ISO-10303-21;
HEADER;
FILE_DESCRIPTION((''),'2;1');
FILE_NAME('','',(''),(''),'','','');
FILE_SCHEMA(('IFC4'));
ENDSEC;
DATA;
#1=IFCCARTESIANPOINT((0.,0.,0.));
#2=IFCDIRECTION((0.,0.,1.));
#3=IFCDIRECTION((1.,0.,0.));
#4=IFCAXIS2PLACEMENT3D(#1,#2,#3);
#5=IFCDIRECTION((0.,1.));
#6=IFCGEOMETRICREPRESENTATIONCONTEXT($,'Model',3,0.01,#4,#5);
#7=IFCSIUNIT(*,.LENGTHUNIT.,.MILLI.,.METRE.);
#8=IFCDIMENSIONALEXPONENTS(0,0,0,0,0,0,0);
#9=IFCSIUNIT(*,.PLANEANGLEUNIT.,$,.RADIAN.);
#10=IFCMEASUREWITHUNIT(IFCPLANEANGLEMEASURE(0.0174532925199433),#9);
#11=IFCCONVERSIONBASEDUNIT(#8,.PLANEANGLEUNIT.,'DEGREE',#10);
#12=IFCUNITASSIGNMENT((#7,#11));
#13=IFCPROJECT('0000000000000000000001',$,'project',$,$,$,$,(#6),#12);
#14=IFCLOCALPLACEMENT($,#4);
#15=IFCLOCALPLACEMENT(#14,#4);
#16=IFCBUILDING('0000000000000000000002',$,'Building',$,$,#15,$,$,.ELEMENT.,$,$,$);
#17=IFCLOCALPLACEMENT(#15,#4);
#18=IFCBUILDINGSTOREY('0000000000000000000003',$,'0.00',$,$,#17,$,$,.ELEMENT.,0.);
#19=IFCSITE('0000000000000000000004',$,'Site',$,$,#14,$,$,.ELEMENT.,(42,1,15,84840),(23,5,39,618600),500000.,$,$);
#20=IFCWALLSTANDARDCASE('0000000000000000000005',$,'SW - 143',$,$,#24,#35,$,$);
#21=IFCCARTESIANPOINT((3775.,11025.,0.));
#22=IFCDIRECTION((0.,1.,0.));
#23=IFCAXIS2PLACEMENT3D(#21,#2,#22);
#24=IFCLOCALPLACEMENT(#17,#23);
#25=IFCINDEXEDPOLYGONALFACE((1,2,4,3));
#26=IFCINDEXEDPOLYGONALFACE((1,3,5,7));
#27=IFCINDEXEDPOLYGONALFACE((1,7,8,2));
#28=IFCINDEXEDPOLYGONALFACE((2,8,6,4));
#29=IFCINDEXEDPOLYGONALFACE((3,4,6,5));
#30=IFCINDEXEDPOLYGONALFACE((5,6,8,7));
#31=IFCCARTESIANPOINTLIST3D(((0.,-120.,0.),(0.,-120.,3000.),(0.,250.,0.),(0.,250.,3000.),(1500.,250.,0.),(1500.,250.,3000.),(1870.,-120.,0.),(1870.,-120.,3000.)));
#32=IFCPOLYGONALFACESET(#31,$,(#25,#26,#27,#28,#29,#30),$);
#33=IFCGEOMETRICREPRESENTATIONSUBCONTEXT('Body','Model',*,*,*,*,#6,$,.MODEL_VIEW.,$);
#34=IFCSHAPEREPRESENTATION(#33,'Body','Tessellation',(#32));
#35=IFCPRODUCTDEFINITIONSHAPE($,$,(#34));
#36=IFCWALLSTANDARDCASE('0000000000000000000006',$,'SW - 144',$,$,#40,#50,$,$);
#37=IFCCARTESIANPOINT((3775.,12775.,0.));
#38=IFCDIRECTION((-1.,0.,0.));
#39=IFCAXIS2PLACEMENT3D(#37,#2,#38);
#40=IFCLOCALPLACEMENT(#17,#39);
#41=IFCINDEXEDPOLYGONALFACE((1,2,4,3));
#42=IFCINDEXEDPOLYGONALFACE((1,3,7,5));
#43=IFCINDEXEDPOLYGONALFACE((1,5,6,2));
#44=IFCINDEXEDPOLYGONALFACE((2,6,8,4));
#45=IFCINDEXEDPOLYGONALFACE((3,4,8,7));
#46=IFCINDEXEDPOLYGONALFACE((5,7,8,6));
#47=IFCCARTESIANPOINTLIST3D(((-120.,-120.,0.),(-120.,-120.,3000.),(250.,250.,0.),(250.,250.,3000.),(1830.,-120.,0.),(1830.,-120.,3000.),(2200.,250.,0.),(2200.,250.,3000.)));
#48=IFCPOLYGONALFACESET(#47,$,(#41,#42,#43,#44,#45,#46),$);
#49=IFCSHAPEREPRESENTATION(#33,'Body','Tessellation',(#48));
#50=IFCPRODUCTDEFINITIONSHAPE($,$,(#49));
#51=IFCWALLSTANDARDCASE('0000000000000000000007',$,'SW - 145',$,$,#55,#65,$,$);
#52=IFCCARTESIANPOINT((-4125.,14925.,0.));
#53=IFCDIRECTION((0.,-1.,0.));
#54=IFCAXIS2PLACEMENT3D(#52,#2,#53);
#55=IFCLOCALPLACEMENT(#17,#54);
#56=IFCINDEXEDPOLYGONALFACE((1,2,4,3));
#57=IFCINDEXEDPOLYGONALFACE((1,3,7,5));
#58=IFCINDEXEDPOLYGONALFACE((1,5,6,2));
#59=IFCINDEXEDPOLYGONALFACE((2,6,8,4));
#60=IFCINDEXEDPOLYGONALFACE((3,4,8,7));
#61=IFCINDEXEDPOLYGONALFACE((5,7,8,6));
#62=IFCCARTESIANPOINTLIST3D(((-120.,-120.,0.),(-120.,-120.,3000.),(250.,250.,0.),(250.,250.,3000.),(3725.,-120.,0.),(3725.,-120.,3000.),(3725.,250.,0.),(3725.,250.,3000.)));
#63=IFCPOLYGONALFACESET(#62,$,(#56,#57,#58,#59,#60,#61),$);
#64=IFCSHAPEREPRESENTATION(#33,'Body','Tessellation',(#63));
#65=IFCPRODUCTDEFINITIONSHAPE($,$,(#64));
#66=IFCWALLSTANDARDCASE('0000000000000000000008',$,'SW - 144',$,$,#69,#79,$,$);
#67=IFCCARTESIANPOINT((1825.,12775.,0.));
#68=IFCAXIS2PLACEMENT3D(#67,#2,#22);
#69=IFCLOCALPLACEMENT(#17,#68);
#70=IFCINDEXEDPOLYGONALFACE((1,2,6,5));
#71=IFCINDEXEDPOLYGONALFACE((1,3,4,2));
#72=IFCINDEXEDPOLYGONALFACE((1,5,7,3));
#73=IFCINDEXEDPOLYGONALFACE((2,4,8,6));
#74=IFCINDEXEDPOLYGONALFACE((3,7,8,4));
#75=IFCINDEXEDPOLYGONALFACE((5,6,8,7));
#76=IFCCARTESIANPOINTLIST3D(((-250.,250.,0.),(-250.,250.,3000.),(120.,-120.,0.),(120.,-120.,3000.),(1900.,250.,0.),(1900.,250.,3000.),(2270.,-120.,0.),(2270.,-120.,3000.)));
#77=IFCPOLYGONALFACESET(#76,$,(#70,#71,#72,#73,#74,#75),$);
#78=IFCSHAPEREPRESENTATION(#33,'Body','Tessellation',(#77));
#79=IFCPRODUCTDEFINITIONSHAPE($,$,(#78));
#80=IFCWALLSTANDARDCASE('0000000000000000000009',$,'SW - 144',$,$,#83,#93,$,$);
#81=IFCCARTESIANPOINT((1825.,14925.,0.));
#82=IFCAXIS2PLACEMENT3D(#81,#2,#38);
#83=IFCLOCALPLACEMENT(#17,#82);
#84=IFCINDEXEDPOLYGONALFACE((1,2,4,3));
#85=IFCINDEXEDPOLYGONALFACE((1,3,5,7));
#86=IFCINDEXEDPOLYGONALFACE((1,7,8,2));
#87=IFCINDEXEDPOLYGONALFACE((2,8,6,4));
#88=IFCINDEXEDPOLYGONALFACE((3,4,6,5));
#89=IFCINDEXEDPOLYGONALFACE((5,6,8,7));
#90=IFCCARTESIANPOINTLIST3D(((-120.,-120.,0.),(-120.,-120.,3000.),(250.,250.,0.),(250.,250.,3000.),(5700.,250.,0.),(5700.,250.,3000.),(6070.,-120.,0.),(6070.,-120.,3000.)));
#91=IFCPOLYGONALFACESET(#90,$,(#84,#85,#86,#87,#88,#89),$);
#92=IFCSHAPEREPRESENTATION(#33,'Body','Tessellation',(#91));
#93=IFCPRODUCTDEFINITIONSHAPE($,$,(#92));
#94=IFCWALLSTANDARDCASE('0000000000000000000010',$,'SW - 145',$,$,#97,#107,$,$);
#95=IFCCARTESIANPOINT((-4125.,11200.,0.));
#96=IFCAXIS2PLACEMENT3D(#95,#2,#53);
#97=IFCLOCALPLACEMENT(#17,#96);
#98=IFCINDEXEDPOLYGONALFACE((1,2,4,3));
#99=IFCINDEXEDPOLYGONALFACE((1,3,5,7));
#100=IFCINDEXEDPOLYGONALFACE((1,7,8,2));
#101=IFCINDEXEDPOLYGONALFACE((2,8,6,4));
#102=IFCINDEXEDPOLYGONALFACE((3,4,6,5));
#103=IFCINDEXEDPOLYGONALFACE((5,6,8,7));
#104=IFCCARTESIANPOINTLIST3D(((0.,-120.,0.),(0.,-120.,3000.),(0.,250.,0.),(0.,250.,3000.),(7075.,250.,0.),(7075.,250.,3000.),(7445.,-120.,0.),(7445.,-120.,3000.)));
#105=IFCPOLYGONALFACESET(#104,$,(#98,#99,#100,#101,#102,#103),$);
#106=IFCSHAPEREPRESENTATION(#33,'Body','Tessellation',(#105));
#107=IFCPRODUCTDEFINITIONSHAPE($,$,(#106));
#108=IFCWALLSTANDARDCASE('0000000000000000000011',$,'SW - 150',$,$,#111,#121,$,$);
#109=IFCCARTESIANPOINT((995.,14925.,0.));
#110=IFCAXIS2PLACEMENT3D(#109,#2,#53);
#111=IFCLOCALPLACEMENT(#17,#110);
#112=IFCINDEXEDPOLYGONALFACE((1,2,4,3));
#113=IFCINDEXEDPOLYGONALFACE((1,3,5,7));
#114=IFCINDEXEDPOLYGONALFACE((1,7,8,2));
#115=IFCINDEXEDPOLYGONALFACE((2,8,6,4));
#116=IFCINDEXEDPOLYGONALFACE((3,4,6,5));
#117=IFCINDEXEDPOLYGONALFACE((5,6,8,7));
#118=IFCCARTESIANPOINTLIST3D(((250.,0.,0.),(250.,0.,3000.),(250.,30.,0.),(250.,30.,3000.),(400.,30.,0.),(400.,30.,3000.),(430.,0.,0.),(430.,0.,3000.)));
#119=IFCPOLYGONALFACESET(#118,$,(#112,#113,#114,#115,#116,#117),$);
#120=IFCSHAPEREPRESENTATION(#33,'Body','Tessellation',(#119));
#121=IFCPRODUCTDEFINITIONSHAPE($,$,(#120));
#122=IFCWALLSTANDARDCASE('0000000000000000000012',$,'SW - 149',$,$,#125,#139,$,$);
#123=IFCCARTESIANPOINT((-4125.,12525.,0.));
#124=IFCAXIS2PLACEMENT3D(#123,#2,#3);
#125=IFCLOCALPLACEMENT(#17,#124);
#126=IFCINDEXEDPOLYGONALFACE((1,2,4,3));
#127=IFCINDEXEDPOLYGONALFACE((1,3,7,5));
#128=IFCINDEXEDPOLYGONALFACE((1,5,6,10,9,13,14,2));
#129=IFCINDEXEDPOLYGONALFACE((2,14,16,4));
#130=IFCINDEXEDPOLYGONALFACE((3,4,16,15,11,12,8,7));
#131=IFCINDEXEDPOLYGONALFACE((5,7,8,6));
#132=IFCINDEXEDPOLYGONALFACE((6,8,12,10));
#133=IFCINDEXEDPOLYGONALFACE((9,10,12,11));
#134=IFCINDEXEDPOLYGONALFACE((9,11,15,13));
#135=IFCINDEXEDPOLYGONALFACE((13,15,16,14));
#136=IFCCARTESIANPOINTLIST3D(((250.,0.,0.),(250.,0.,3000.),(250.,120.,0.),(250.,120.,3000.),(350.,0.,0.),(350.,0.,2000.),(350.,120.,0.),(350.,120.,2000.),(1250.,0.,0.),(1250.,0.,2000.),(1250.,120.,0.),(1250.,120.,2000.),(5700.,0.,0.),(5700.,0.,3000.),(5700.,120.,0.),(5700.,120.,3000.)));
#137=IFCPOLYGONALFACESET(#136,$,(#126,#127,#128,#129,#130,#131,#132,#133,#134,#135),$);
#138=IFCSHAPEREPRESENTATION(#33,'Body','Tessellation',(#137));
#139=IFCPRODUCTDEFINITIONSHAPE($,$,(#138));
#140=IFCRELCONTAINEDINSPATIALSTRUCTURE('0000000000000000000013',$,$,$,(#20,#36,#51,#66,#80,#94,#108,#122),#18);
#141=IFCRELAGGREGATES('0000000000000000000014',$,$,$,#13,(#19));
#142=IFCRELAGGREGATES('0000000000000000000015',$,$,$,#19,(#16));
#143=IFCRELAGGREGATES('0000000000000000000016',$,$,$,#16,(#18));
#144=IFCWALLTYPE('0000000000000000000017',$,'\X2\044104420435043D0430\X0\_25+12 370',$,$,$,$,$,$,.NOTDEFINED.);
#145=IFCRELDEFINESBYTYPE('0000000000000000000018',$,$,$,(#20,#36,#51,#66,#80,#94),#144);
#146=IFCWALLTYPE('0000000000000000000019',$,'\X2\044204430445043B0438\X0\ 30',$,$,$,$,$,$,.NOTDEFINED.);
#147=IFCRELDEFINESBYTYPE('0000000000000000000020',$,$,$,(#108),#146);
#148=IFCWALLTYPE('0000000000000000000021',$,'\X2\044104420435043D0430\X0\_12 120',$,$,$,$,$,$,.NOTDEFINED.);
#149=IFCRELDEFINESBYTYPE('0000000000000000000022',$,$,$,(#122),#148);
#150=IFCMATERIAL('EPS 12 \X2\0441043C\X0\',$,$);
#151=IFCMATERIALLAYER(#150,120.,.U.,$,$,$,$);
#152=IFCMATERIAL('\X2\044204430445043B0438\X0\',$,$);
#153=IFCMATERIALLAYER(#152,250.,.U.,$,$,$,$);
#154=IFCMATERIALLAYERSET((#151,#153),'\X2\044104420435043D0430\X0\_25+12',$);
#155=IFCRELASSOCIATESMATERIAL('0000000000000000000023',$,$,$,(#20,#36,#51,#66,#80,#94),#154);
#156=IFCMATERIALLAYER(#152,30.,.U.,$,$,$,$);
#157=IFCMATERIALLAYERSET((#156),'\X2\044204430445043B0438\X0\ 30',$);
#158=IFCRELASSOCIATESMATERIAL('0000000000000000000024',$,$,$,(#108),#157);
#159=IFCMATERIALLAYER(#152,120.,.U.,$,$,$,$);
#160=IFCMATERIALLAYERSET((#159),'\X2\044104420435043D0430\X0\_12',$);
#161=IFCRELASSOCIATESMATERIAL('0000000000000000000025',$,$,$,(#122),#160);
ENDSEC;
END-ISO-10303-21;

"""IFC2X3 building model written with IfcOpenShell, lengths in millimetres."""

from ifc_helpers import new_model, entity, si_unit, converted_unit, direction, frame, origin_with_axes, origin_2d_with_axis, place, context, subcontext, project, spatial, polyline, rectangle, outline, extrude, material, layer, layer_set, layer_usage, type_object, element, save


model = new_model("IFC2X3")

# Units and contexts
model_context = context("Model", 3, precision=0.01, world=origin_with_axes(), true_north=direction((0.0, 1.0)))
body_context = subcontext(model_context, "Body", "Model", "MODEL_VIEW")
ifc_project = project(units=[si_unit("LENGTHUNIT", "METRE", prefix="MILLI"), converted_unit("PLANEANGLEUNIT", "DEGREE", entity("IfcPlaneAngleMeasure", 0.0174532925199433), si_unit("PLANEANGLEUNIT", "RADIAN"), dimensions=[0, 0, 0, 0, 0, 0, 0])], contexts=[model_context])

# Site, building, storey
site_placement = place(None, origin_with_axes())
site = spatial("IfcSite", under=ifc_project, at=site_placement, Name="Site", CompositionType="ELEMENT", RefLatitude=(42, 1, 15, 84840), RefLongitude=(23, 5, 39, 618600), RefElevation=500000.0)
building_placement = place(site_placement, origin_with_axes())
building = spatial("IfcBuilding", under=site, at=building_placement, Name="Building", CompositionType="ELEMENT")
storey_placement = place(building_placement, origin_with_axes())
storey = spatial("IfcBuildingStorey", under=building, at=storey_placement, Name="0.00", CompositionType="ELEMENT", Elevation=0.0)

# Walls
ifc_material_1 = material(Name="EPS 12 см")
ifc_layer_1 = layer(ifc_material_1, 120.0, ventilated="UNKNOWN")
ifc_material_2 = material(Name="тухли")
ifc_layer_2 = layer(ifc_material_2, 250.0, ventilated="UNKNOWN")
ifc_layer_set_1 = layer_set([ifc_layer_1, ifc_layer_2], Name="стена_25+12")
ifc_layer_usage_1 = layer_usage(ifc_layer_set_1, "AXIS2", "POSITIVE", -120.0)
wall_type_1 = type_object("IfcWallType", Name="стена_25+12 370", PredefinedType="NOTDEFINED")
wall_1_placement = place(storey_placement, frame((3775.0, 11025.0, 0.0), z_axis=(0.0, 0.0, 1.0), x_axis=(0.0, 1.0, 0.0)))
element("IfcWallStandardCase", 1, at=wall_1_placement, inside=storey, type_object=wall_type_1, material=ifc_layer_usage_1, Name="SW - 143", context=body_context, shape_type="SweptSolid", body=[
    extrude(outline(polyline([(0.0, -120.0), (1870.0, -120.0), (1500.0, 250.0), (0.0, 250.0), (0.0, -120.0)])), origin_with_axes(), (0.0, 0.0, 1.0), 3000.0),
])
ifc_layer_usage_2 = layer_usage(ifc_layer_set_1, "AXIS2", "POSITIVE", -120.0)
wall_2_placement = place(storey_placement, frame((3775.0, 12775.0, 0.0), z_axis=(0.0, 0.0, 1.0), x_axis=(-1.0, 0.0, 0.0)))
element("IfcWallStandardCase", 2, at=wall_2_placement, inside=storey, type_object=wall_type_1, material=ifc_layer_usage_2, Name="SW - 144", context=body_context, shape_type="SweptSolid", body=[
    extrude(outline(polyline([(-120.0, -120.0), (1830.0, -120.0), (2200.0, 250.0), (250.0, 250.0), (-120.0, -120.0)])), origin_with_axes(), (0.0, 0.0, 1.0), 3000.0),
])
ifc_layer_usage_3 = layer_usage(ifc_layer_set_1, "AXIS2", "POSITIVE", -120.0)
wall_3_placement = place(storey_placement, frame((-4125.0, 14925.0, 0.0), z_axis=(0.0, 0.0, 1.0), x_axis=(0.0, -1.0, 0.0)))
element("IfcWallStandardCase", 3, at=wall_3_placement, inside=storey, type_object=wall_type_1, material=ifc_layer_usage_3, Name="SW - 145", context=body_context, shape_type="SweptSolid", body=[
    extrude(outline(polyline([(-120.0, -120.0), (3725.0, -120.0), (3725.0, 250.0), (250.0, 250.0), (-120.0, -120.0)])), origin_with_axes(), (0.0, 0.0, 1.0), 3000.0),
])
ifc_layer_usage_4 = layer_usage(ifc_layer_set_1, "AXIS2", "POSITIVE", -120.0)
wall_4_placement = place(storey_placement, frame((1825.0, 12775.0, 0.0), z_axis=(0.0, 0.0, 1.0), x_axis=(0.0, 1.0, 0.0)))
element("IfcWallStandardCase", 4, at=wall_4_placement, inside=storey, type_object=wall_type_1, material=ifc_layer_usage_4, Name="SW - 144", context=body_context, shape_type="SweptSolid", body=[
    extrude(outline(polyline([(120.0, -120.0), (2270.0, -120.0), (1900.0, 250.0), (-250.0, 250.0), (120.0, -120.0)])), origin_with_axes(), (0.0, 0.0, 1.0), 3000.0),
])
ifc_layer_usage_5 = layer_usage(ifc_layer_set_1, "AXIS2", "POSITIVE", -120.0)
wall_5_placement = place(storey_placement, frame((1825.0, 14925.0, 0.0), z_axis=(0.0, 0.0, 1.0), x_axis=(-1.0, 0.0, 0.0)))
element("IfcWallStandardCase", 5, at=wall_5_placement, inside=storey, type_object=wall_type_1, material=ifc_layer_usage_5, Name="SW - 144", context=body_context, shape_type="SweptSolid", body=[
    extrude(outline(polyline([(-120.0, -120.0), (6070.0, -120.0), (5700.0, 250.0), (250.0, 250.0), (-120.0, -120.0)])), origin_with_axes(), (0.0, 0.0, 1.0), 3000.0),
])
ifc_layer_usage_6 = layer_usage(ifc_layer_set_1, "AXIS2", "POSITIVE", -120.0)
wall_6_placement = place(storey_placement, frame((-4125.0, 11200.0, 0.0), z_axis=(0.0, 0.0, 1.0), x_axis=(0.0, -1.0, 0.0)))
element("IfcWallStandardCase", 6, at=wall_6_placement, inside=storey, type_object=wall_type_1, material=ifc_layer_usage_6, Name="SW - 145", context=body_context, shape_type="SweptSolid", body=[
    extrude(outline(polyline([(0.0, -120.0), (7445.0, -120.0), (7075.0, 250.0), (0.0, 250.0), (0.0, -120.0)])), origin_with_axes(), (0.0, 0.0, 1.0), 3000.0),
])
ifc_layer_3 = layer(ifc_material_2, 30.0, ventilated="UNKNOWN")
ifc_layer_set_2 = layer_set([ifc_layer_3], Name="тухли 30")
wall_type_2 = type_object("IfcWallType", Name="тухли 30", PredefinedType="NOTDEFINED")
ifc_layer_usage_7 = layer_usage(ifc_layer_set_2, "AXIS2", "POSITIVE", 0.0)
wall_7_placement = place(storey_placement, frame((995.0, 14925.0, 0.0), z_axis=(0.0, 0.0, 1.0), x_axis=(0.0, -1.0, 0.0)))
element("IfcWallStandardCase", 7, at=wall_7_placement, inside=storey, type_object=wall_type_2, material=ifc_layer_usage_7, Name="SW - 150", context=body_context, shape_type="SweptSolid", body=[
    extrude(outline(polyline([(250.0, 0.0), (430.0, 0.0), (400.0, 30.0), (250.0, 30.0), (250.0, 0.0)])), origin_with_axes(), (0.0, 0.0, 1.0), 3000.0),
])

# Wall, opening
ifc_layer_4 = layer(ifc_material_2, 120.0, ventilated="UNKNOWN")
ifc_layer_set_3 = layer_set([ifc_layer_4], Name="стена_12")
ifc_layer_usage_8 = layer_usage(ifc_layer_set_3, "AXIS2", "POSITIVE", 0.0)
wall_type_3 = type_object("IfcWallType", Name="стена_12 120", PredefinedType="NOTDEFINED")
wall_8_placement = place(storey_placement, frame((-4125.0, 12525.0, 0.0), z_axis=(0.0, 0.0, 1.0), x_axis=(1.0, 0.0, 0.0)))
wall_8 = element("IfcWallStandardCase", 8, at=wall_8_placement, inside=storey, type_object=wall_type_3, material=ifc_layer_usage_8, Name="SW - 149", context=body_context, shape_type="SweptSolid", body=[
    extrude(outline(polyline([(250.0, 0.0), (5700.0, 0.0), (5700.0, 120.0), (250.0, 120.0), (250.0, 0.0)])), origin_with_axes(), (0.0, 0.0, 1.0), 3000.0),
])
opening_placement = place(wall_8_placement, frame((800.0, 0.0, 0.0), z_axis=(0.0, 0.0, 1.0), x_axis=(1.0, 0.0, 0.0)))
element("IfcOpeningElement", 9, at=opening_placement, cuts=wall_8, context=body_context, shape_type="SweptSolid", body=[
    extrude(rectangle(XDim=900.0, YDim=2000.0, at=origin_2d_with_axis()), frame((0.0, -120.0, 1000.0), z_axis=(0.0, -1.0, 0.0), x_axis=(-1.0, 0.0, 0.0)), (0.0, 0.0, -1.0), 360.0),
])

save(model, "model.ifc")
